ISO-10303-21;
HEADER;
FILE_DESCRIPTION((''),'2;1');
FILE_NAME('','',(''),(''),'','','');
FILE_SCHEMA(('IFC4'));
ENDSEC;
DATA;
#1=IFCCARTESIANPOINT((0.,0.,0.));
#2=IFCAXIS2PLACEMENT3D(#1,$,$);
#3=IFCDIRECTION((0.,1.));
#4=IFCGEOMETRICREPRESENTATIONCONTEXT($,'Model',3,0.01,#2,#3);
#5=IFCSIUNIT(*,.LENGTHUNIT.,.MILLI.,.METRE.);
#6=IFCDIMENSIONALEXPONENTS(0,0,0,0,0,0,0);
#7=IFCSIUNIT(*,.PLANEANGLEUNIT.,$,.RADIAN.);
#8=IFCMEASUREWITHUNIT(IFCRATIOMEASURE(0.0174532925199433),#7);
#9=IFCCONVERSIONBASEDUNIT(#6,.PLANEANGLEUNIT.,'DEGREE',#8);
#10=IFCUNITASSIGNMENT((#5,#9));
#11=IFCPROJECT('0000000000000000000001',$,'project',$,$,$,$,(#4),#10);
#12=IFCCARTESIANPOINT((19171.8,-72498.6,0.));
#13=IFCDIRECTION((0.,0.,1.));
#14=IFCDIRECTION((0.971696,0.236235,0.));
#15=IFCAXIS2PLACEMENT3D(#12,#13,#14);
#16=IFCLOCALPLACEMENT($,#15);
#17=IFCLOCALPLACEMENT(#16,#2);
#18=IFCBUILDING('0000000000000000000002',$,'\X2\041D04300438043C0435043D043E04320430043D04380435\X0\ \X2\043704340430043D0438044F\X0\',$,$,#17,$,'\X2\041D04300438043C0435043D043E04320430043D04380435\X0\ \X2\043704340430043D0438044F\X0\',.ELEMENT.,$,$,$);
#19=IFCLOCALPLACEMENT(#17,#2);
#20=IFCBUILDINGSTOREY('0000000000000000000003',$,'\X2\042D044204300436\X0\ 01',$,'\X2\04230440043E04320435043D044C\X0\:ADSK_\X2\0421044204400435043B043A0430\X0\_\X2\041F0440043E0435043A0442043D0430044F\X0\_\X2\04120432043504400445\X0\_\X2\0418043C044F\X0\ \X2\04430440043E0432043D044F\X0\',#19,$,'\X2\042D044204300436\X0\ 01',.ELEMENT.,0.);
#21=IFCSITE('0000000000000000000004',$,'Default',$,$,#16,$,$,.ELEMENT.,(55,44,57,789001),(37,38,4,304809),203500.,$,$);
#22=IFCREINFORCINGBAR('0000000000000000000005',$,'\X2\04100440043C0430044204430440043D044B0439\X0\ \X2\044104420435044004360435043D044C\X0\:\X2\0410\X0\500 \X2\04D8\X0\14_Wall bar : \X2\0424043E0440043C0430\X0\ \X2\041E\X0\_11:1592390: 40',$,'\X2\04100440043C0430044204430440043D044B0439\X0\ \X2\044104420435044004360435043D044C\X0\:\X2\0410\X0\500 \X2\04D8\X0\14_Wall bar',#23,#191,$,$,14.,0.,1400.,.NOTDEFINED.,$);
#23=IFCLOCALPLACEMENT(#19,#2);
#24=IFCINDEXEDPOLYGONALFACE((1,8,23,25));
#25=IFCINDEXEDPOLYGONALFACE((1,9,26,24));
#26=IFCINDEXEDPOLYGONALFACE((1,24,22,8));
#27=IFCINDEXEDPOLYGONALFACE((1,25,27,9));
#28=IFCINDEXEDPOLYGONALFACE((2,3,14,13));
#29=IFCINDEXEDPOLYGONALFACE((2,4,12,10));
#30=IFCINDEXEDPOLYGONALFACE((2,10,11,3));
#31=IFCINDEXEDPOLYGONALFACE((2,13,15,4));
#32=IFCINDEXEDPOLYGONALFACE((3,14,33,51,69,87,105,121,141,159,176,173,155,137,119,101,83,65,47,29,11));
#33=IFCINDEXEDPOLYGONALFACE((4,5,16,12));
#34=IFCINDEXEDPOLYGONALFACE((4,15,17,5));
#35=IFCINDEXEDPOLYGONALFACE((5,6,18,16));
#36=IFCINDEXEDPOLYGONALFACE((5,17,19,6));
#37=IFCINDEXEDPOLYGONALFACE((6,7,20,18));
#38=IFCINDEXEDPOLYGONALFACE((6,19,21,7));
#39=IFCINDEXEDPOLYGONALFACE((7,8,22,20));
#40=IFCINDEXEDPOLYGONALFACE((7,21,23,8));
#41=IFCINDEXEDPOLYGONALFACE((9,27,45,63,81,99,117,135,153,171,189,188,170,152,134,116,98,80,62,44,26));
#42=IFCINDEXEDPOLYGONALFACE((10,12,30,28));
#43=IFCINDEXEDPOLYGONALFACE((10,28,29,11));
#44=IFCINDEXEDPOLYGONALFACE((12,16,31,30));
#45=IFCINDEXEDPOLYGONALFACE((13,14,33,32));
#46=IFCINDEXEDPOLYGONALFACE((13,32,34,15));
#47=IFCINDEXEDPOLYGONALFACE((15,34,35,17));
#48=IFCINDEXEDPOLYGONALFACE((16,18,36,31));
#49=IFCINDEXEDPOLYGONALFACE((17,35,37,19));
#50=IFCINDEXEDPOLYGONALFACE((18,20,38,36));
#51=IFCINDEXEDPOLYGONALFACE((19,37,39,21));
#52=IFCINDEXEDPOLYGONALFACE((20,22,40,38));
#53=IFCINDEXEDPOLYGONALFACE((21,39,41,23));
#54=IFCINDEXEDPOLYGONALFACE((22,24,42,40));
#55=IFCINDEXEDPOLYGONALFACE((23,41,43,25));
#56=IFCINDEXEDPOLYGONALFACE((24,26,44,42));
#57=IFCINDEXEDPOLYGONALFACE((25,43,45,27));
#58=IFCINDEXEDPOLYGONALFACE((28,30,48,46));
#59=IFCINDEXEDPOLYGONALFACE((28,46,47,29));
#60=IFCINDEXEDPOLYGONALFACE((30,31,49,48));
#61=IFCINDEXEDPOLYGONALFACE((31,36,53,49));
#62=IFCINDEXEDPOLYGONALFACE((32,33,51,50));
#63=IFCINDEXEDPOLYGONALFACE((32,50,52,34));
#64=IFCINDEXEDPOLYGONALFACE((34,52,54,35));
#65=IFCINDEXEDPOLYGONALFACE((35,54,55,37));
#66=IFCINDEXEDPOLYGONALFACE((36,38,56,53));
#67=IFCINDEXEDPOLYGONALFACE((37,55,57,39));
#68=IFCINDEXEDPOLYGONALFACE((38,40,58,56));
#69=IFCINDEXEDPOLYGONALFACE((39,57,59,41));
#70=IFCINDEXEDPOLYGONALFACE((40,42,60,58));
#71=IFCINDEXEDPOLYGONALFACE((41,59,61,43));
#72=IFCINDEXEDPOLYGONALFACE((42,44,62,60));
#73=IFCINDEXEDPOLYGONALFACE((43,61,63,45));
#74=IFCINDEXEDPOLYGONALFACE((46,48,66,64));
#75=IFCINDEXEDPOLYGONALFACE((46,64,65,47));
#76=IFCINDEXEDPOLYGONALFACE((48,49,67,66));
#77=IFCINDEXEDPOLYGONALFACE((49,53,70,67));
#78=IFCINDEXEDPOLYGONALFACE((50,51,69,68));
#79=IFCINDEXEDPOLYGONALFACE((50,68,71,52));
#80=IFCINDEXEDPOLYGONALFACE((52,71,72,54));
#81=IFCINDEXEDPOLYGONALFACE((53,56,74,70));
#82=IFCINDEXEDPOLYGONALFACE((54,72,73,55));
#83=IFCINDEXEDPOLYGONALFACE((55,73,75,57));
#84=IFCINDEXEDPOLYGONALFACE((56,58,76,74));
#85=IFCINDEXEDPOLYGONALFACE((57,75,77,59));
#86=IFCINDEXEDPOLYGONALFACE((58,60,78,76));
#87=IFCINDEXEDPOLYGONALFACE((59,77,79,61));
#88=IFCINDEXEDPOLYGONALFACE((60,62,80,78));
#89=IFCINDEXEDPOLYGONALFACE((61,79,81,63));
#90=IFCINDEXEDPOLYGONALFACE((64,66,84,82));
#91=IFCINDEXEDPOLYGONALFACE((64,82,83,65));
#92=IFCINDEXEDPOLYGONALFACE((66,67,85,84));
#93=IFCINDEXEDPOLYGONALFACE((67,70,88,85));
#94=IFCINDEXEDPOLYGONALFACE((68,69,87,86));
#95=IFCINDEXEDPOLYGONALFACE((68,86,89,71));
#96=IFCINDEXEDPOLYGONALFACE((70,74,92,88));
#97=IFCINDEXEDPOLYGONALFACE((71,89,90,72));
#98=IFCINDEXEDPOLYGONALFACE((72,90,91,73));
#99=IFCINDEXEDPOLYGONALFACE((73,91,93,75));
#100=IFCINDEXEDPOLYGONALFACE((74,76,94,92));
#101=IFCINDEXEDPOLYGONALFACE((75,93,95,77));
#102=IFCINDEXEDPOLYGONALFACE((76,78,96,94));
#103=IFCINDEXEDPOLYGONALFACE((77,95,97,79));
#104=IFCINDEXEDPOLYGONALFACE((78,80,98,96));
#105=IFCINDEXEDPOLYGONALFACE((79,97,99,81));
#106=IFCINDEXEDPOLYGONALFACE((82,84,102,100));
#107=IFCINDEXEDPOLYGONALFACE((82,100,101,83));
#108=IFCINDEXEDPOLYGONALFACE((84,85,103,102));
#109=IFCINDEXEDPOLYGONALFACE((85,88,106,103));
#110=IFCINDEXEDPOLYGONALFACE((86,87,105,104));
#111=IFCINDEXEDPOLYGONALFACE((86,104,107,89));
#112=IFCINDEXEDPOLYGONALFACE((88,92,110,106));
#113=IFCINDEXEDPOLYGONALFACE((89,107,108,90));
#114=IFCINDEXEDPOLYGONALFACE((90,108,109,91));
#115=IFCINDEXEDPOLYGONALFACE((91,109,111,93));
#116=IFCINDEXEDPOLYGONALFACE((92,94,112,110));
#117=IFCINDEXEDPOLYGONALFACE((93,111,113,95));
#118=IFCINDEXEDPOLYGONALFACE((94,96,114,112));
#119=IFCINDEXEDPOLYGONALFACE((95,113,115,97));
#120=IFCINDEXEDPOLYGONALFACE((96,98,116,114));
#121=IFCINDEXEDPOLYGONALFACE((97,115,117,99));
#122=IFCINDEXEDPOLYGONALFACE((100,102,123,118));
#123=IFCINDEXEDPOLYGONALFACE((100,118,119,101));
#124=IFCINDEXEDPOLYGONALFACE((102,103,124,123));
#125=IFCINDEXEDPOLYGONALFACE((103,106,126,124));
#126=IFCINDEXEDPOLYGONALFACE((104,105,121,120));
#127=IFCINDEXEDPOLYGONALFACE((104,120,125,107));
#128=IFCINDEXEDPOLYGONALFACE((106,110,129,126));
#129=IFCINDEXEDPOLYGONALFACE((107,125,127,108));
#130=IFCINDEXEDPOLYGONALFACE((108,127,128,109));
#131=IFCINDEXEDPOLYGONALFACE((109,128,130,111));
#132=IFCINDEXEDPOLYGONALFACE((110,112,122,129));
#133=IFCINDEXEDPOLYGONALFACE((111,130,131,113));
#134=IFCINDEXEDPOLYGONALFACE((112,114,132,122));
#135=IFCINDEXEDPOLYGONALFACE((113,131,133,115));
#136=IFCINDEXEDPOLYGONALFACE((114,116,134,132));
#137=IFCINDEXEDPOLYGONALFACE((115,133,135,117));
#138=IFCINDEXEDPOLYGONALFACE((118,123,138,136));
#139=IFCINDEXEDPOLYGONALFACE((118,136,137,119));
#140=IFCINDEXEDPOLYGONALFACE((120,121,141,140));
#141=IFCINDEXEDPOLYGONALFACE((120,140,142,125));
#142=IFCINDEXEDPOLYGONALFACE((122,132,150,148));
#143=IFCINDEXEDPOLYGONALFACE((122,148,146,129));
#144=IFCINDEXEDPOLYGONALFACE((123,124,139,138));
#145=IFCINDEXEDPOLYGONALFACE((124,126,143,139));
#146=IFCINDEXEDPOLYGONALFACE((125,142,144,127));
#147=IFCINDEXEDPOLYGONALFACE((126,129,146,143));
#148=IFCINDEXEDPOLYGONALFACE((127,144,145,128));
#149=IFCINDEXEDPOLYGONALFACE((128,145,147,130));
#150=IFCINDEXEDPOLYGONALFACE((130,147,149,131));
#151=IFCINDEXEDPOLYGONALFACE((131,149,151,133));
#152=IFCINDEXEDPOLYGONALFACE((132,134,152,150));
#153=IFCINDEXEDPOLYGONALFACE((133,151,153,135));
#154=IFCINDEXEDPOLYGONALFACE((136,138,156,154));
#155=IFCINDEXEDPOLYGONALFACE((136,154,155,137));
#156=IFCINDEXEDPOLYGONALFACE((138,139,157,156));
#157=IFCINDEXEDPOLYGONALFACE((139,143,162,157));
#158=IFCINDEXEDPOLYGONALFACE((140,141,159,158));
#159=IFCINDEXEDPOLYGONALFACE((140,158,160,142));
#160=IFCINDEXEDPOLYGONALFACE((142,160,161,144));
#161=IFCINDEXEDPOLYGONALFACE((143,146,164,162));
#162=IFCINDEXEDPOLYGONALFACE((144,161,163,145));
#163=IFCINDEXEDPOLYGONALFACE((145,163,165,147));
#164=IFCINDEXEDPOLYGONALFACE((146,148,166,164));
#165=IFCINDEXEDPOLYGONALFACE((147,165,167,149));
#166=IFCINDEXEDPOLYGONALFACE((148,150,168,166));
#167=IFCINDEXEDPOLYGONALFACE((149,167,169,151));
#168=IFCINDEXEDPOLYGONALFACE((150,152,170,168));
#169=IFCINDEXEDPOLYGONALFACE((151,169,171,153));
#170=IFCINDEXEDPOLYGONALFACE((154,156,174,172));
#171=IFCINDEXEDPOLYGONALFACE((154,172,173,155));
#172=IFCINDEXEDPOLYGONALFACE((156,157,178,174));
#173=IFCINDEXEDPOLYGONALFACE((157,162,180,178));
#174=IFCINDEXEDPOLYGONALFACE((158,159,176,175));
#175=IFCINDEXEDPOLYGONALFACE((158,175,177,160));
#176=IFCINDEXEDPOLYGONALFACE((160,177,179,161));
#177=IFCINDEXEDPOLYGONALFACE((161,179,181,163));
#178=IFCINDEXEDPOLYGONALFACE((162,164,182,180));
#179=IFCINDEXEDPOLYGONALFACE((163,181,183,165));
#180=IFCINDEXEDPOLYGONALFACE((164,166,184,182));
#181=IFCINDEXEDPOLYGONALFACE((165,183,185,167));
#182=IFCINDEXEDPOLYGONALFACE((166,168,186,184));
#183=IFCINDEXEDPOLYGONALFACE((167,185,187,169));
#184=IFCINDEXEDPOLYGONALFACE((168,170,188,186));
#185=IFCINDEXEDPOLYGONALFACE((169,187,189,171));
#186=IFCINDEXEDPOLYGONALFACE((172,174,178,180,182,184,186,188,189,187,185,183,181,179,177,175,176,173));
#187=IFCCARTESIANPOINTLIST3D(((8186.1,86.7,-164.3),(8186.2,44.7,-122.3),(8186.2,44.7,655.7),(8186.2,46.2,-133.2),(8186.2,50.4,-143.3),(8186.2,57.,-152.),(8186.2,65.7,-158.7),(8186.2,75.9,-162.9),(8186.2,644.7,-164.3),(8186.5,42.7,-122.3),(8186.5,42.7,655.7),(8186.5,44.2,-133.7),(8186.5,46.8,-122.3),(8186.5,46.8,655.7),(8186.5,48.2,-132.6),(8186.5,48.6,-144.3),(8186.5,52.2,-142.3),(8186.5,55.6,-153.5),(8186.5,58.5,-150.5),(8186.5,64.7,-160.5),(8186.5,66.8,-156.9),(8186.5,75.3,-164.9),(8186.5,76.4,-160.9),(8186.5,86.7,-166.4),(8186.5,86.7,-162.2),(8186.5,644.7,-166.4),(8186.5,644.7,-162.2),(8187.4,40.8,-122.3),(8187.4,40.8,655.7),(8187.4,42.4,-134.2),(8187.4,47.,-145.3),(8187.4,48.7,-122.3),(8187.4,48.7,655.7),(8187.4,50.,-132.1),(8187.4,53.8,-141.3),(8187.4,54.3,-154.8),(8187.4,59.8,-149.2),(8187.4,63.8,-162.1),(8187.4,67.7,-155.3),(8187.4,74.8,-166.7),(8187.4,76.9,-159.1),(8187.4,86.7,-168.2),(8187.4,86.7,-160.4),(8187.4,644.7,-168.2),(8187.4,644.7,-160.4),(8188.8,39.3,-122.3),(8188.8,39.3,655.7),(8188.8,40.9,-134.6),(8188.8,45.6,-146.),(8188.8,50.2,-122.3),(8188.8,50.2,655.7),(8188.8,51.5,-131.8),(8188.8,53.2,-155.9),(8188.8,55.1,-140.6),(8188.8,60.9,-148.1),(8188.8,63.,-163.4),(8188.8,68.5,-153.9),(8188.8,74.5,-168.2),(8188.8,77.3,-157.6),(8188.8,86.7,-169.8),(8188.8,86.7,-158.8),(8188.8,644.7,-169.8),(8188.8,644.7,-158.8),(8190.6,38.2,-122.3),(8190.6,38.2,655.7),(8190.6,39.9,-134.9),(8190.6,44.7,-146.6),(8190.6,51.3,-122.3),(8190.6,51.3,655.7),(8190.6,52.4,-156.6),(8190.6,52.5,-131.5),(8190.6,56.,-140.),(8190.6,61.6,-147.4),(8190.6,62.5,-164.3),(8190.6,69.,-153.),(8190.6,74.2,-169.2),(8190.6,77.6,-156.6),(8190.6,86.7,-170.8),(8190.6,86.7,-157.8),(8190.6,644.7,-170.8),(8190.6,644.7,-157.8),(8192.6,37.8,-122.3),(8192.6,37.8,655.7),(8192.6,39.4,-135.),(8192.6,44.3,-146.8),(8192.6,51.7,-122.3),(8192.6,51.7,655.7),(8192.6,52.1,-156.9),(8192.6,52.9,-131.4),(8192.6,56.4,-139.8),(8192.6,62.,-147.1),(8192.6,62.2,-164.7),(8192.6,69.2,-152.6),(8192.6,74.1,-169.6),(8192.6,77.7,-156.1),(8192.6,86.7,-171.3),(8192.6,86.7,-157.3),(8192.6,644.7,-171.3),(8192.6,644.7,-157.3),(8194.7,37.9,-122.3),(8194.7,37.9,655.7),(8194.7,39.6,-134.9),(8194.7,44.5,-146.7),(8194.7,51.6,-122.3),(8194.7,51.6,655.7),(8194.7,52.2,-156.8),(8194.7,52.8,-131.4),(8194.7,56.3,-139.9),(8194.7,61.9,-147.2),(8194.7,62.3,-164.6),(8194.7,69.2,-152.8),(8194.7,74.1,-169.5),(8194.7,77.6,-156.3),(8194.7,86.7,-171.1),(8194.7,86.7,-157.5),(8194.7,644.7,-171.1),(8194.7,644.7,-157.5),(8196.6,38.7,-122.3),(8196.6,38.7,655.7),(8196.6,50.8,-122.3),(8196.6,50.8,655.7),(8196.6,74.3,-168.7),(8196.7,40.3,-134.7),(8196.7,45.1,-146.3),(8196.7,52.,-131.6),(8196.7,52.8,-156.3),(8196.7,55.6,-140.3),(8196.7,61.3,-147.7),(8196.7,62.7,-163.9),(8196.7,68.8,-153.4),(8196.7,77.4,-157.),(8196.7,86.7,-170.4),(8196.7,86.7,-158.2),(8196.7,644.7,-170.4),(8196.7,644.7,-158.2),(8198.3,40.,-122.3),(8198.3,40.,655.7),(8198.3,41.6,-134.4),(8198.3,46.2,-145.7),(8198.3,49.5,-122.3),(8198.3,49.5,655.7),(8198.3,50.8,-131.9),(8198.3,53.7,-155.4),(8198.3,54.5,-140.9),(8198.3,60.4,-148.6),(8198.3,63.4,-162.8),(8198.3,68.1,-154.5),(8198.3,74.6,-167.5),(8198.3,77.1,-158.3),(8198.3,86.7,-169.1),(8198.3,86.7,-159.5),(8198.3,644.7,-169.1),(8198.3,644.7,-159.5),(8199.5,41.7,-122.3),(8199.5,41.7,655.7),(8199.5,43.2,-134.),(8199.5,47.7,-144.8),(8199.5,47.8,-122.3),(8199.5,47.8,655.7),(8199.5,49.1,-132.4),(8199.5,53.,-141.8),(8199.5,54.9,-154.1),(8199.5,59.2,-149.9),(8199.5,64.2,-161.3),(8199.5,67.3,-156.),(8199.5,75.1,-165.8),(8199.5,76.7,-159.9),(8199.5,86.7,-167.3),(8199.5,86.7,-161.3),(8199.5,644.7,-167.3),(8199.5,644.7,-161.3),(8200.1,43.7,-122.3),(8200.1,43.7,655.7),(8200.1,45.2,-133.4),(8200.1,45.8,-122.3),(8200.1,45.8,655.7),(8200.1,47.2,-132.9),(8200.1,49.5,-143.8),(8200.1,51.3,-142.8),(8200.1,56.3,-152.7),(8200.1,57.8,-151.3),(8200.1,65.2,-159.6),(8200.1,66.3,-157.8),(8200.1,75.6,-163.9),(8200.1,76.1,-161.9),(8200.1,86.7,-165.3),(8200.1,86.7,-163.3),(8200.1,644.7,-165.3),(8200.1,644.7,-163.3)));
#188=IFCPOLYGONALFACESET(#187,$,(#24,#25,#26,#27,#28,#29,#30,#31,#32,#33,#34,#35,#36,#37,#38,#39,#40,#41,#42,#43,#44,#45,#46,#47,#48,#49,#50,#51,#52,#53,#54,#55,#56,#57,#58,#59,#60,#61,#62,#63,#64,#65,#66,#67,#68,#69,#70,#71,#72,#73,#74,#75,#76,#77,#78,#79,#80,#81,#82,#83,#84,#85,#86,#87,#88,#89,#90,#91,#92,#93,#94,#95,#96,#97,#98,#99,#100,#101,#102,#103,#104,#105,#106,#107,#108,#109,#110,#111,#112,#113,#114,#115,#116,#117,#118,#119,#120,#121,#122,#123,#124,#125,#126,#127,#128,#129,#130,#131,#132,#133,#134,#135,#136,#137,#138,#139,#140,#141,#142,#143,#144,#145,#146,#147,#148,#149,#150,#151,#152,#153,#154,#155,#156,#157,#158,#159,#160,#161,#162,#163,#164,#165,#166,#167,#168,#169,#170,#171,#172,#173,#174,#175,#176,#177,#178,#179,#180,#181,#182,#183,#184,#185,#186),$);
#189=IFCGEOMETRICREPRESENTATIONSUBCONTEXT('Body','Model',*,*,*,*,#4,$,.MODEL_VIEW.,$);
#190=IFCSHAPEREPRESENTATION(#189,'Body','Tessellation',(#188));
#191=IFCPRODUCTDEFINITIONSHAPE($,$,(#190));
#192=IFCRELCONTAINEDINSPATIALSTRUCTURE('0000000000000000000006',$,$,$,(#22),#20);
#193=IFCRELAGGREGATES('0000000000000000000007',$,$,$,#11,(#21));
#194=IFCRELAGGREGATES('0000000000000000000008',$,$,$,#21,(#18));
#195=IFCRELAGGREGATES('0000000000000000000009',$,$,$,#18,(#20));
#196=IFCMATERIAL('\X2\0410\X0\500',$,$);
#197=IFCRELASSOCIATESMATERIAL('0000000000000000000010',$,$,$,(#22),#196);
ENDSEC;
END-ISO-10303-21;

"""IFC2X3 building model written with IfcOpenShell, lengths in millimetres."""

from ifc_helpers import new_model, entity, si_unit, converted_unit, direction, frame, origin, place, context, subcontext, project, spatial, material, element, save


model = new_model("IFC2X3")

# Units and contexts
model_context = context("Model", 3, precision=0.01, world=origin(), true_north=direction((0.0, 1.0)))
body_context = subcontext(model_context, "Body", "Model", "MODEL_VIEW")
ifc_project = project(units=[si_unit("LENGTHUNIT", "METRE", prefix="MILLI"), converted_unit("PLANEANGLEUNIT", "DEGREE", entity("IfcRatioMeasure", 0.0174532925199433), si_unit("PLANEANGLEUNIT", "RADIAN"), dimensions=[0, 0, 0, 0, 0, 0, 0])], contexts=[model_context])

# Site, building, storey
site_placement = place(None, frame((19171.8, -72498.6, 0.0), z_axis=(0.0, 0.0, 1.0), x_axis=(0.971696, 0.236235, 0.0)))
site = spatial("IfcSite", under=ifc_project, at=site_placement, Name="Default", CompositionType="ELEMENT", RefLatitude=(55, 44, 57, 789001), RefLongitude=(37, 38, 4, 304809), RefElevation=203500.0)
building_placement = place(site_placement, origin())
building = spatial("IfcBuilding", under=site, at=building_placement, Name="Наименование здания", LongName="Наименование здания", CompositionType="ELEMENT")
storey_placement = place(building_placement, origin())
storey = spatial("IfcBuildingStorey", under=building, at=storey_placement, Name="Этаж 01", ObjectType="Уровень:ADSK_Стрелка_Проектная_Вверх_Имя уровня", LongName="Этаж 01", CompositionType="ELEMENT", Elevation=0.0)

# Reinforcing bar
ifc_material = material(Name="А500")
placement = place(storey_placement, origin())
element("IfcReinforcingBar", 1, at=placement, inside=storey, material=ifc_material, Name="Арматурный стержень:А500 Ә14_Wall bar : Форма О_11:1592390: 40", ObjectType="Арматурный стержень:А500 Ә14_Wall bar", BarLength=1400.0, BarRole="NOTDEFINED", CrossSectionArea=0.0, NominalDiameter=14.0, context=body_context, shape_type="AdvancedSweptSolid", body=[
    entity("IfcSweptDiskSolid", entity("IfcCompositeCurve", [entity("IfcCompositeCurveSegment", "CONTINUOUS", True, entity("IfcPolyline", [entity("IfcCartesianPoint", [8193.1, 44.7, 655.7]), entity("IfcCartesianPoint", [8193.1, 44.7, -122.3])])), entity("IfcCompositeCurveSegment", "CONTINUOUS", True, entity("IfcTrimmedCurve", entity("IfcCircle", entity("IfcAxis2Placement3D", entity("IfcCartesianPoint", [8193.1, 86.7, -122.3]), entity("IfcDirection", [1.0, 0.0, 0.0]), entity("IfcDirection", [0.0, 0.0, -1.0])), 42.0), [entity("IfcParameterValue", 270.0)], [entity("IfcParameterValue", 360.0)], True, "PARAMETER")), entity("IfcCompositeCurveSegment", "CONTINUOUS", True, entity("IfcPolyline", [entity("IfcCartesianPoint", [8193.1, 86.7, -164.3]), entity("IfcCartesianPoint", [8193.1, 644.7, -164.3])]))], False), 7.0, None, 0.0, 92.0),
])

save(model, "model.ifc")
